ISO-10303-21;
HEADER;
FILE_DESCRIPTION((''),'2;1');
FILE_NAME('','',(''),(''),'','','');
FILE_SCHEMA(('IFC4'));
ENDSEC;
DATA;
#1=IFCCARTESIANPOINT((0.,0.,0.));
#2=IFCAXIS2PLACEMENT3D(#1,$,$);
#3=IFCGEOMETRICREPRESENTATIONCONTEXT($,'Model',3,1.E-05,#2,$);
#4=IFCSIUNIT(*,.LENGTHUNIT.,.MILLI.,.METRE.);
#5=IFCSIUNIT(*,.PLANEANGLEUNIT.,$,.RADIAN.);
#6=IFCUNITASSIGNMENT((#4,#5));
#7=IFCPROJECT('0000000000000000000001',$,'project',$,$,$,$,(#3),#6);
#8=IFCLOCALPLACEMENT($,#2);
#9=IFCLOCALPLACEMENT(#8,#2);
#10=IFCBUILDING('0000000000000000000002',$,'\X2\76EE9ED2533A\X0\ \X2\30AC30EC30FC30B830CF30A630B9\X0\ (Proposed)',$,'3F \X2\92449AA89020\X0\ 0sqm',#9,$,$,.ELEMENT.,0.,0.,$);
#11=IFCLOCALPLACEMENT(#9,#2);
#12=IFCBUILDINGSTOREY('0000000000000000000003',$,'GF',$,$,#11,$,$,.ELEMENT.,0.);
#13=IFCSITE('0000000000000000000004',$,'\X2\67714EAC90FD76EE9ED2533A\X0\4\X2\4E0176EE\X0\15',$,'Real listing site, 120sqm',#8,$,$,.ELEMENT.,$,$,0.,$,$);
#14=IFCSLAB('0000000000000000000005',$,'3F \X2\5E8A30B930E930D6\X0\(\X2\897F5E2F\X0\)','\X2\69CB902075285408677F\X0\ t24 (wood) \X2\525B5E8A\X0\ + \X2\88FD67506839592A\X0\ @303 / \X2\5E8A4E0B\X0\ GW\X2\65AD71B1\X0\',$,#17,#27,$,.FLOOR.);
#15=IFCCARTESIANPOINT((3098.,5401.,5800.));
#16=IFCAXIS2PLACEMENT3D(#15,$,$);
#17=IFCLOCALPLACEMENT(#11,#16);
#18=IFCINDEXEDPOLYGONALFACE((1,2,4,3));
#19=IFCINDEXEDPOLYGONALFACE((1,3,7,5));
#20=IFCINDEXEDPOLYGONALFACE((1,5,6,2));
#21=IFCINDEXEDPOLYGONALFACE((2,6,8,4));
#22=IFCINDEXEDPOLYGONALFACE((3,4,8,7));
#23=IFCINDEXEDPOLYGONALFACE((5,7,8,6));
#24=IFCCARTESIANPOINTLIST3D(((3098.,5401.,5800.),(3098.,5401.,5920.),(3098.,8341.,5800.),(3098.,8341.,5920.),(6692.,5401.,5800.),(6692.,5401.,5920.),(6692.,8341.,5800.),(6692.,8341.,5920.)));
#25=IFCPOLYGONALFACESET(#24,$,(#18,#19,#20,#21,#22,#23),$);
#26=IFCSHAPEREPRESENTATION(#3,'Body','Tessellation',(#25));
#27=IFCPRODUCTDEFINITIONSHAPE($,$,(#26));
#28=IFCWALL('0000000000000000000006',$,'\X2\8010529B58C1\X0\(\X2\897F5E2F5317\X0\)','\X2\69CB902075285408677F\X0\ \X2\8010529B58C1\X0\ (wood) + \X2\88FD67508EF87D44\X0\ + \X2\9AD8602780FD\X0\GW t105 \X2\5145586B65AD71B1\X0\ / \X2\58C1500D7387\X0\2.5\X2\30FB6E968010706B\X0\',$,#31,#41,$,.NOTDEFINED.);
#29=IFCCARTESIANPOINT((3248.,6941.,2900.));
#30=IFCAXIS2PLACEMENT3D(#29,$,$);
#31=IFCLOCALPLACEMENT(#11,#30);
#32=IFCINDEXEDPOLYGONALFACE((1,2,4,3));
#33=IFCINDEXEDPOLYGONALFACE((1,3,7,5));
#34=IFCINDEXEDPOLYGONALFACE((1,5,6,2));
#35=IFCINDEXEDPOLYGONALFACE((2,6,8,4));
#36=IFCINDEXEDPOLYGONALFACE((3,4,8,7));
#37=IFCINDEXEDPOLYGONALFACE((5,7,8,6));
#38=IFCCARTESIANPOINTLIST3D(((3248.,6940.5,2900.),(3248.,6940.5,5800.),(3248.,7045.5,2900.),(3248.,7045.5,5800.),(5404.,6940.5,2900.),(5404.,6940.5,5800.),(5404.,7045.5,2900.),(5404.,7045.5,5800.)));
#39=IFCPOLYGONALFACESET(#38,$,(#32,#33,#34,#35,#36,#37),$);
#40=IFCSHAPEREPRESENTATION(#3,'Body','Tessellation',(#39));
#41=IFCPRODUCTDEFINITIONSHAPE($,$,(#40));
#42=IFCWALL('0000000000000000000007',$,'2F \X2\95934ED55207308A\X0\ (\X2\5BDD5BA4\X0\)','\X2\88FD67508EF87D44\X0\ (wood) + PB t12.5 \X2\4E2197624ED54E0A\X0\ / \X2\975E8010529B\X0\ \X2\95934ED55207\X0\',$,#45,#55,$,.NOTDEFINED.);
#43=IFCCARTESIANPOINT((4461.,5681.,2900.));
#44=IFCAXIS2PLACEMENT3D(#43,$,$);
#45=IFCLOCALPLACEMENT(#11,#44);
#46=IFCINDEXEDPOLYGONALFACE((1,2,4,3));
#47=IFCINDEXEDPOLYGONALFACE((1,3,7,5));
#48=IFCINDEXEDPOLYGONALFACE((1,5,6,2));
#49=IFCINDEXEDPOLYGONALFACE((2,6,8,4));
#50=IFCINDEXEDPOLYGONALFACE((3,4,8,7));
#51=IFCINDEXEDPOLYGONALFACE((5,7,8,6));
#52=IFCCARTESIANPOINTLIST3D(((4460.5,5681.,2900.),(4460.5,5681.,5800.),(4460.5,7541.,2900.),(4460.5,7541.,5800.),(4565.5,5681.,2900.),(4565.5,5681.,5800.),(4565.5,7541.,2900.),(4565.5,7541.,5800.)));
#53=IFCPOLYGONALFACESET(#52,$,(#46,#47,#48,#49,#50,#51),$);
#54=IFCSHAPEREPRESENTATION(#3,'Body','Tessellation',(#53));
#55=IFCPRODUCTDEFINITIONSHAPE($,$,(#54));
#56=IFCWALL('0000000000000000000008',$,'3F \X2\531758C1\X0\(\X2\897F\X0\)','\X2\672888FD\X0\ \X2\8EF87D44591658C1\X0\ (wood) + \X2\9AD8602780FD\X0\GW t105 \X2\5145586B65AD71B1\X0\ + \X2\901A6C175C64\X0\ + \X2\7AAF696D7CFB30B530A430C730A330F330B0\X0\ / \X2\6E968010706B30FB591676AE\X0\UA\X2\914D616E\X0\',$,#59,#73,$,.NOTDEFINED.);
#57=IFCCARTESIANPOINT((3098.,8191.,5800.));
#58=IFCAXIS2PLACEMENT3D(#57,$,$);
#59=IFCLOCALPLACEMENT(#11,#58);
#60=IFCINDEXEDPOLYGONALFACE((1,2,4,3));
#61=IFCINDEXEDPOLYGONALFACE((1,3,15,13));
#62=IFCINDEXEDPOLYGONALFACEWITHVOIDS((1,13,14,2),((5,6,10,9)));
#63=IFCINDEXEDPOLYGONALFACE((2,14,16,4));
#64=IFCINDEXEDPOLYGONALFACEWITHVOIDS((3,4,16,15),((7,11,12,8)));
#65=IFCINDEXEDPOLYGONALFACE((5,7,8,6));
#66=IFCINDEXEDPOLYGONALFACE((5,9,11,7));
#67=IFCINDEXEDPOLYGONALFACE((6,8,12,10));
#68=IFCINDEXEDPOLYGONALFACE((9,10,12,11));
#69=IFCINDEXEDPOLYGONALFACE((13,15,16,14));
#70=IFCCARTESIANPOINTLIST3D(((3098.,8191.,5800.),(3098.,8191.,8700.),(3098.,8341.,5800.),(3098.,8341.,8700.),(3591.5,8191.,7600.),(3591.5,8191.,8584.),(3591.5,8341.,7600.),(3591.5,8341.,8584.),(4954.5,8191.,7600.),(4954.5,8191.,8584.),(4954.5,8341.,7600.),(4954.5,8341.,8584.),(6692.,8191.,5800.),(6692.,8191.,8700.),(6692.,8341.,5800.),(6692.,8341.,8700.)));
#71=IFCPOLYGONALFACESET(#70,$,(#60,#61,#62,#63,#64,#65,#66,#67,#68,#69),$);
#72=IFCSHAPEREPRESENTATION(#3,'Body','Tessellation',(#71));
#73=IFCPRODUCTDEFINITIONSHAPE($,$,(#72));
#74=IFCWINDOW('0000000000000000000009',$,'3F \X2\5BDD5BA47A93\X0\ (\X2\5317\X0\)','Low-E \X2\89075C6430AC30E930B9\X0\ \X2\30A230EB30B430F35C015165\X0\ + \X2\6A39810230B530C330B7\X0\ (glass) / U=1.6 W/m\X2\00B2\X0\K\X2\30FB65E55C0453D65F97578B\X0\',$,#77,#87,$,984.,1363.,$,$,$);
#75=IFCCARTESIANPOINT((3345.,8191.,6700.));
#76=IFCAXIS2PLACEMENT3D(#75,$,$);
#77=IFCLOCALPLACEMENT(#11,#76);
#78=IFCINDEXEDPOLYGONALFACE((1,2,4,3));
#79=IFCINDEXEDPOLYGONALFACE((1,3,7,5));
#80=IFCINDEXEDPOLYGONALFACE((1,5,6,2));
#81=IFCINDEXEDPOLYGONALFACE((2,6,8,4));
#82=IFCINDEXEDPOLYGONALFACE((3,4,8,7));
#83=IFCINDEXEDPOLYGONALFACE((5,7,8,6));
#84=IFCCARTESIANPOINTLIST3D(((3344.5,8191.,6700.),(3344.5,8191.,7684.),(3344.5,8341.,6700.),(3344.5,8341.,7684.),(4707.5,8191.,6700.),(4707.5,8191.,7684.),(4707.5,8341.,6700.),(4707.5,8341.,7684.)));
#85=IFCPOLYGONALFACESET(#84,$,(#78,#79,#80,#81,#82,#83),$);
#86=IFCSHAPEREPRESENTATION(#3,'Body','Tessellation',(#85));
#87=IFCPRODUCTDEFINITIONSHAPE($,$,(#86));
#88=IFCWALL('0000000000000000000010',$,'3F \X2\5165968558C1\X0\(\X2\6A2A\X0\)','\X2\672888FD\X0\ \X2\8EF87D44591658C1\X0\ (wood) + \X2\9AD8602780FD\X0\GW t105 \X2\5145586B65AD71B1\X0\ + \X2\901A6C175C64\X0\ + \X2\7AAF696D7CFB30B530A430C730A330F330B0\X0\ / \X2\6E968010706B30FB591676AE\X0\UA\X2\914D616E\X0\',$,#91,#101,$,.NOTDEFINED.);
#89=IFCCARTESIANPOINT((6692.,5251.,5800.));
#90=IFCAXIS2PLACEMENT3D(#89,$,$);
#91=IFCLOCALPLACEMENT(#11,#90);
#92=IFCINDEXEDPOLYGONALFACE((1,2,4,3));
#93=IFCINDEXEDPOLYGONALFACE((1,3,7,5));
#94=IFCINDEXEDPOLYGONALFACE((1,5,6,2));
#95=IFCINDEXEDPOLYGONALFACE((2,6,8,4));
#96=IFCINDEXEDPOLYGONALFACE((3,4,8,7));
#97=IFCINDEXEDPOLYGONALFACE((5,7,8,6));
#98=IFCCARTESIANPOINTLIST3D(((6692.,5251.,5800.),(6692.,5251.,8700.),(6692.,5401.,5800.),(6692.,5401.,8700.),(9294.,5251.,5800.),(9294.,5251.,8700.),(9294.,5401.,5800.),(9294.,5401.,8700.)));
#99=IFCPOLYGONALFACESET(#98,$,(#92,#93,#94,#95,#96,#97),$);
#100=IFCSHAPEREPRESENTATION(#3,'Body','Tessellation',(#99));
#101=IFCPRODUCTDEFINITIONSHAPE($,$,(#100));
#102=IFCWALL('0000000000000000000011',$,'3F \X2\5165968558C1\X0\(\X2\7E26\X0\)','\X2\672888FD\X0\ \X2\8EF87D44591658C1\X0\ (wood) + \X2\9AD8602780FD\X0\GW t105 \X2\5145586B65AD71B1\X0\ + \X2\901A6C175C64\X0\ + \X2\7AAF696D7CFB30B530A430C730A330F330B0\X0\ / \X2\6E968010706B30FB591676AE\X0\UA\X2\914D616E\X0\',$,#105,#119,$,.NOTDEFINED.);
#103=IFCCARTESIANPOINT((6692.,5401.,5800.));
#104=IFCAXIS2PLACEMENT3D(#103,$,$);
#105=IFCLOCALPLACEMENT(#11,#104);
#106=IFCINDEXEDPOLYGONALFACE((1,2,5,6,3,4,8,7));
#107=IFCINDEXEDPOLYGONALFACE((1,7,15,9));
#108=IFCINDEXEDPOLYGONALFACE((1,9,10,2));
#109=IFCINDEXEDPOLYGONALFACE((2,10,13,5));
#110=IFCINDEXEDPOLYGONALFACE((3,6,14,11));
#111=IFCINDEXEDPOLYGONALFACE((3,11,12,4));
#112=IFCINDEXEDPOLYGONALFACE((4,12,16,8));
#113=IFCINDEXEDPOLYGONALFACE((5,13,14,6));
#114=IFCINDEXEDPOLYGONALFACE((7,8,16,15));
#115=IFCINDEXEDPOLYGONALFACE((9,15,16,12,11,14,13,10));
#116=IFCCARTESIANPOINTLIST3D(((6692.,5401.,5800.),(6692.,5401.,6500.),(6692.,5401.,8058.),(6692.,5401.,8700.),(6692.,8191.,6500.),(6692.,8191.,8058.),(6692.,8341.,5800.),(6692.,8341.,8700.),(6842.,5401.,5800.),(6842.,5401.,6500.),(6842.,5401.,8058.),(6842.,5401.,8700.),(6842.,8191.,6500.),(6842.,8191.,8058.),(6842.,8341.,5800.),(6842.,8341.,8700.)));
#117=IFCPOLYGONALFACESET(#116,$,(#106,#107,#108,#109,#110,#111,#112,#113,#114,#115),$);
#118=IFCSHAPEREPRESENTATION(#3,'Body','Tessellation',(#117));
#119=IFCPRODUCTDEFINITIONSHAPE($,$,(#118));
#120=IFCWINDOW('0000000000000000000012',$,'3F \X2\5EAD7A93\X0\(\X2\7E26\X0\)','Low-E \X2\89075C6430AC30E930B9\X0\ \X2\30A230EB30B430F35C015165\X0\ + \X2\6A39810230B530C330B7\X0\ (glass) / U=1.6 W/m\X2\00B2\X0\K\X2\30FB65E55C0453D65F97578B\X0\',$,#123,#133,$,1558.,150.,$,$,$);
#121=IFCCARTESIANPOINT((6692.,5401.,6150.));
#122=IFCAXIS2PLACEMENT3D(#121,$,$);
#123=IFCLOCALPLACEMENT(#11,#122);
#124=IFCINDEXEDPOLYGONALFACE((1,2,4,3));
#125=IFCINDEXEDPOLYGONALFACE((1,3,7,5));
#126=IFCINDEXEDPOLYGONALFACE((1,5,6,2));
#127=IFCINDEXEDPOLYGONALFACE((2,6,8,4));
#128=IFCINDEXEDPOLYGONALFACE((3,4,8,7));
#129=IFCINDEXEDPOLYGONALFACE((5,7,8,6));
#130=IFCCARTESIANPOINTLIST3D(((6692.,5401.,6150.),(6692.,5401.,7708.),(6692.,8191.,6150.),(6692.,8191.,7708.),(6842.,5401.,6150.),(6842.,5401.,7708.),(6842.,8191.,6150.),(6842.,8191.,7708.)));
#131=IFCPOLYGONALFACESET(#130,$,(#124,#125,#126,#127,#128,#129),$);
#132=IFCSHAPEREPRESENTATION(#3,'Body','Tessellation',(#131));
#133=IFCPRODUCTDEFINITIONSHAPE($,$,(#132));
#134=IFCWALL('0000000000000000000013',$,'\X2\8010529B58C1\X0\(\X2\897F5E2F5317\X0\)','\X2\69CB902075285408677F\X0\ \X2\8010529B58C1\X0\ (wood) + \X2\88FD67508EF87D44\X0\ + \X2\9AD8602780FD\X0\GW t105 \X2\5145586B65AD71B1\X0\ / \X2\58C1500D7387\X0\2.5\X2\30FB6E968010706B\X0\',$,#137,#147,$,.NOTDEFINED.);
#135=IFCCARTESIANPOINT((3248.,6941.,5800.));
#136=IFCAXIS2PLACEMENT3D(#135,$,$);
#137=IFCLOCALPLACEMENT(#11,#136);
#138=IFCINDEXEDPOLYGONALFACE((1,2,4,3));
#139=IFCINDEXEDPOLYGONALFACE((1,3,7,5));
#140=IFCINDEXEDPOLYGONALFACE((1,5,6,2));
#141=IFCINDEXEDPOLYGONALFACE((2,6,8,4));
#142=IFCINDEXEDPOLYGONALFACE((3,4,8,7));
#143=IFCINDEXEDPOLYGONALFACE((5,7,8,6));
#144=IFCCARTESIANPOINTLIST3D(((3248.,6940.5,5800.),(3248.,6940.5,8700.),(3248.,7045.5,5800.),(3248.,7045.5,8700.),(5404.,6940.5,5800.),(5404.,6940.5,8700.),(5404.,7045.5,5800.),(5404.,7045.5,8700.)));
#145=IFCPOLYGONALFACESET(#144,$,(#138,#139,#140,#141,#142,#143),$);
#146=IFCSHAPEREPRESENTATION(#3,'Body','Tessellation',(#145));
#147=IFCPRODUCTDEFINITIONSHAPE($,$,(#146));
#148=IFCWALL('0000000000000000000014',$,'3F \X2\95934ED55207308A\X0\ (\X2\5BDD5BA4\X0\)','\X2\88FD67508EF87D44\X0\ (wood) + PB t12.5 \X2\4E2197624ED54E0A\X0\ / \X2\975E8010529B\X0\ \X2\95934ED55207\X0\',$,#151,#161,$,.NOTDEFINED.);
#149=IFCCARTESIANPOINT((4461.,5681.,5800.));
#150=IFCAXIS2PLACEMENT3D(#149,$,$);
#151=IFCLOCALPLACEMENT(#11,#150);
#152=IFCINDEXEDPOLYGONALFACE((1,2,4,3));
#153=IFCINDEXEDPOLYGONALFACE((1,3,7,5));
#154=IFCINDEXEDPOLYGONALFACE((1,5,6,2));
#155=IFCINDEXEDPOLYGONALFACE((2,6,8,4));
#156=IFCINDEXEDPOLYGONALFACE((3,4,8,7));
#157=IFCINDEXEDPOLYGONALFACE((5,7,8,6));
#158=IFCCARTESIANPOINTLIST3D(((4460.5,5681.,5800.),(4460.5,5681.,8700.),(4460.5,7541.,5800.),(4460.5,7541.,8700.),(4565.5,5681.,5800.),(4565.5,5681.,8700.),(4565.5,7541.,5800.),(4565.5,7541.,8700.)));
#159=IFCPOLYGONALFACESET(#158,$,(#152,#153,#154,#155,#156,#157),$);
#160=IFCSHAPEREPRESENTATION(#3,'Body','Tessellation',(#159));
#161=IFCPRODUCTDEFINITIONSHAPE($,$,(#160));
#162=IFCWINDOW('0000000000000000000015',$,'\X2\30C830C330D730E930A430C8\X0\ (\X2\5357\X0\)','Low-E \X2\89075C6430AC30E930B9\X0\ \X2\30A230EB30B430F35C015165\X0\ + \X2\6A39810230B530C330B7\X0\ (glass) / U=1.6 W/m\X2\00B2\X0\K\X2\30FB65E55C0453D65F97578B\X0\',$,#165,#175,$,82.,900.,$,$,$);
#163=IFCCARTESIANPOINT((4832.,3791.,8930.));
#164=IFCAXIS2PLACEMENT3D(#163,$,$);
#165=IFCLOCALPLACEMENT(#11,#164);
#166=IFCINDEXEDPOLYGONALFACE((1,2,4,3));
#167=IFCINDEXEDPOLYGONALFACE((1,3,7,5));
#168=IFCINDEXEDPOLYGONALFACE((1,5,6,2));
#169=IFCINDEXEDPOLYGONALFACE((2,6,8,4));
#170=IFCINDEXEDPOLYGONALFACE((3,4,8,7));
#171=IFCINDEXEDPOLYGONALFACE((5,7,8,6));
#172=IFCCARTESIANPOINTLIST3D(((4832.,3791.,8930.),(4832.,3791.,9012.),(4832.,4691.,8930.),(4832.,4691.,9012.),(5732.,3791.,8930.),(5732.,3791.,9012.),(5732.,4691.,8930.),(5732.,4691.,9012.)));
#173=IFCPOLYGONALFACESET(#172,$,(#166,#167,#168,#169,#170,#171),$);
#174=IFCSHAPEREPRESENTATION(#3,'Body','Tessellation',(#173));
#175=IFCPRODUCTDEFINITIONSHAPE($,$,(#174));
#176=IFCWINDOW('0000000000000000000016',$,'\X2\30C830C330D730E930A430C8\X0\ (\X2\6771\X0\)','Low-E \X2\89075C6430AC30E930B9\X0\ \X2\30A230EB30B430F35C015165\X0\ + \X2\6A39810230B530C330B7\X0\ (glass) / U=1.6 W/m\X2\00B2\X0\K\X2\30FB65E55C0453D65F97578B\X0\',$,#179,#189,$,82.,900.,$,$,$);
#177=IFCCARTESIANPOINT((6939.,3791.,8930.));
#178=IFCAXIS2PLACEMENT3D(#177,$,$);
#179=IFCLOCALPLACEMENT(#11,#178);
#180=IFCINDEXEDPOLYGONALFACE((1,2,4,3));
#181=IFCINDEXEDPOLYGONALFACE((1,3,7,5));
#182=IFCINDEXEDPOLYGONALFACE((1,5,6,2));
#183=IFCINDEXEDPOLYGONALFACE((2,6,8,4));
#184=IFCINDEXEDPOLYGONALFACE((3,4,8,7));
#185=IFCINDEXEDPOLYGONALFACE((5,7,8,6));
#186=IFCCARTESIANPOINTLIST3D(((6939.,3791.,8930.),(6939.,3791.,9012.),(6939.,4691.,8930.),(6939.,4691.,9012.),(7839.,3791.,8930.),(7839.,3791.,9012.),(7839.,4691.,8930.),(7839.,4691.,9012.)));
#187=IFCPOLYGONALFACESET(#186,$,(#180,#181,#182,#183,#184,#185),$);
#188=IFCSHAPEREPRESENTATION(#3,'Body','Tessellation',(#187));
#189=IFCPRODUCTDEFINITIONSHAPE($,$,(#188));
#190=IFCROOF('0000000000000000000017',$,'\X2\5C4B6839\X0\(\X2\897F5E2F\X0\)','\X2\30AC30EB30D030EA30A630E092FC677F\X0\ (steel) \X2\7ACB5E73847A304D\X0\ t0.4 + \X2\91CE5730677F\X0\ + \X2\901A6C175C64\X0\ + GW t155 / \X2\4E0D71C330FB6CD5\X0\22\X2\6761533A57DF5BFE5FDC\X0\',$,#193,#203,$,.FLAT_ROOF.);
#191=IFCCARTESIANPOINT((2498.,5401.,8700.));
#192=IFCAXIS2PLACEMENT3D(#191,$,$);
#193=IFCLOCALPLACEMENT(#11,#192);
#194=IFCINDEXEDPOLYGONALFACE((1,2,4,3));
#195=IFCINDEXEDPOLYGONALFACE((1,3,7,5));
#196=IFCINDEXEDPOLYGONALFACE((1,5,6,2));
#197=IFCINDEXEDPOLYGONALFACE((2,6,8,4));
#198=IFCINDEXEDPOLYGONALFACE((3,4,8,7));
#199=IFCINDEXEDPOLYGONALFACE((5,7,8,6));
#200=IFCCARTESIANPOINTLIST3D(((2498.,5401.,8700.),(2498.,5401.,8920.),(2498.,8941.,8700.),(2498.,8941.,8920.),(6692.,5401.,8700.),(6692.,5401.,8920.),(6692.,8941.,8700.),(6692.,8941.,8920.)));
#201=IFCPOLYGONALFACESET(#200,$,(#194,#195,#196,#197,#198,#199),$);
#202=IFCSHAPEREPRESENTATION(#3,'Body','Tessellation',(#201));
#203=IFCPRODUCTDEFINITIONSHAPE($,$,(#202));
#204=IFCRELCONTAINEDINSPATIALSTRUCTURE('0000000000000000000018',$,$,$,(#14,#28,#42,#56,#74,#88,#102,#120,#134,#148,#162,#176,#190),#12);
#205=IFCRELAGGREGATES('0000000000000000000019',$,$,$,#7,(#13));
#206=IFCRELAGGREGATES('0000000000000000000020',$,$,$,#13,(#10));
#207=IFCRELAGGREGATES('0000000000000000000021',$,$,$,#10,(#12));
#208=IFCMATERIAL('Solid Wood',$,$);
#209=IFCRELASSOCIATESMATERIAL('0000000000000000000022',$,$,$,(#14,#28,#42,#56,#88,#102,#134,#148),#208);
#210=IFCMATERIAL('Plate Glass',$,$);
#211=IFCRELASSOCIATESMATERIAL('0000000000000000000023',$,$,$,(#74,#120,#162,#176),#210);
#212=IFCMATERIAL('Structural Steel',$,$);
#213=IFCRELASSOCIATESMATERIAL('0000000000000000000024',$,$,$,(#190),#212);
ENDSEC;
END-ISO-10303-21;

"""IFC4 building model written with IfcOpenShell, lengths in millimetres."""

from ifc_helpers import new_model, si_unit, frame, frame_2d, origin, place, context, project, spatial, rectangle, extrude, material, element, fill, save


model = new_model("IFC4")

# Units and contexts
model_context = context("Model", 3, precision=1e-05, world=origin())
ifc_project = project(units=[si_unit("LENGTHUNIT", "METRE", prefix="MILLI"), si_unit("PLANEANGLEUNIT", "RADIAN")], contexts=[model_context])

# Site, building, storey
site_placement = place(None, origin())
site = spatial("IfcSite", under=ifc_project, at=site_placement, Name="東京都目黒区4丁目15", ObjectType="Real listing site, 120sqm", CompositionType="ELEMENT", RefElevation=0.0)
building_placement = place(site_placement, origin())
building = spatial("IfcBuilding", under=site, at=building_placement, Name="目黒区 ガレージハウス (Proposed)", ObjectType="3F 鉄骨造 0sqm", CompositionType="ELEMENT", ElevationOfRefHeight=0.0, ElevationOfTerrain=0.0)
storey_placement = place(building_placement, origin())
storey = spatial("IfcBuildingStorey", under=building, at=storey_placement, Name="GF", CompositionType="ELEMENT", Elevation=0.0)

# Slab
ifc_material_1 = material(Name="Solid Wood")
slab_placement = place(storey_placement, frame((3098.0, 5401.0, 5800.0)))
element("IfcSlab", 1, at=slab_placement, inside=storey, material=ifc_material_1, Name="3F 床スラブ(西帯)", Description="構造用合板 t24 (wood) 剛床 + 製材根太 @303 / 床下 GW断熱", PredefinedType="FLOOR", context=model_context, shape_type="SweptSolid", body=[
    extrude(rectangle(XDim=3594.0, YDim=2940.0, at=frame_2d((1797.0, 1470.0))), frame((3098.0, 5401.0, 5800.0)), (0.0, 0.0, 1.0), 120.0),
])

# Walls
wall_1_placement = place(storey_placement, frame((3248.0, 6941.0, 2900.0)))
element("IfcWall", 2, at=wall_1_placement, inside=storey, material=ifc_material_1, Name="耐力壁(西帯北)", Description="構造用合板 耐力壁 (wood) + 製材軸組 + 高性能GW t105 充填断熱 / 壁倍率2.5・準耐火", PredefinedType="NOTDEFINED", context=model_context, shape_type="SweptSolid", body=[
    extrude(rectangle(XDim=2156.0, YDim=105.0, at=frame_2d((1078.0, 52.0))), frame((3248.0, 6941.0, 2900.0)), (0.0, 0.0, 1.0), 2900.0),
])
wall_2_placement = place(storey_placement, frame((4461.0, 5681.0, 2900.0)))
element("IfcWall", 3, at=wall_2_placement, inside=storey, material=ifc_material_1, Name="2F 間仕切り (寝室)", Description="製材軸組 (wood) + PB t12.5 両面仕上 / 非耐力 間仕切", PredefinedType="NOTDEFINED", context=model_context, shape_type="SweptSolid", body=[
    extrude(rectangle(XDim=105.0, YDim=1860.0, at=frame_2d((52.0, 930.0))), frame((4461.0, 5681.0, 2900.0)), (0.0, 0.0, 1.0), 2900.0),
])

# Wall, opening, window
wall_3_placement = place(storey_placement, frame((3098.0, 8191.0, 5800.0)))
wall_3 = element("IfcWall", 4, at=wall_3_placement, inside=storey, material=ifc_material_1, Name="3F 北壁(西)", Description="木製 軸組外壁 (wood) + 高性能GW t105 充填断熱 + 通気層 + 窯業系サイディング / 準耐火・外皮UA配慮", PredefinedType="NOTDEFINED", context=model_context, shape_type="SweptSolid", body=[
    extrude(rectangle(XDim=3594.0, YDim=150.0, at=frame_2d((1797.0, 75.0))), frame((3098.0, 8191.0, 5800.0)), (0.0, 0.0, 1.0), 2900.0),
])
opening_1_placement = place(storey_placement, frame((3345.0, 8191.0, 6700.0)))
opening_1 = element("IfcOpeningElement", 5, at=opening_1_placement, cuts=wall_3, PredefinedType="NOTDEFINED", context=model_context, shape_type="SweptSolid", body=[
    extrude(rectangle(XDim=1363.0, YDim=150.0, at=frame_2d((681.0, 75.0))), frame((3345.0, 8191.0, 6700.0)), (0.0, 0.0, 1.0), 984.0),
])
ifc_material_2 = material(Name="Plate Glass")
window_1_placement = place(storey_placement, frame((3345.0, 8191.0, 6700.0)))
window_1 = element("IfcWindow", 6, at=window_1_placement, inside=storey, material=ifc_material_2, Name="3F 寝室窓 (北)", Description="Low-E 複層ガラス アルゴン封入 + 樹脂サッシ (glass) / U=1.6 W/m²K・日射取得型", OverallHeight=984.0, OverallWidth=1363.0, context=model_context, shape_type="SweptSolid", body=[
    extrude(rectangle(XDim=1363.0, YDim=150.0, at=frame_2d((681.0, 75.0))), frame((3345.0, 8191.0, 6700.0)), (0.0, 0.0, 1.0), 984.0),
])
fill(opening_1, window_1)

# Wall
wall_4_placement = place(storey_placement, frame((6692.0, 5251.0, 5800.0)))
element("IfcWall", 7, at=wall_4_placement, inside=storey, material=ifc_material_1, Name="3F 入隅壁(横)", Description="木製 軸組外壁 (wood) + 高性能GW t105 充填断熱 + 通気層 + 窯業系サイディング / 準耐火・外皮UA配慮", PredefinedType="NOTDEFINED", context=model_context, shape_type="SweptSolid", body=[
    extrude(rectangle(XDim=2602.0, YDim=150.0, at=frame_2d((1301.0, 75.0))), frame((6692.0, 5251.0, 5800.0)), (0.0, 0.0, 1.0), 2900.0),
])

# Wall, opening, window
wall_5_placement = place(storey_placement, frame((6692.0, 5401.0, 5800.0)))
wall_5 = element("IfcWall", 8, at=wall_5_placement, inside=storey, material=ifc_material_1, Name="3F 入隅壁(縦)", Description="木製 軸組外壁 (wood) + 高性能GW t105 充填断熱 + 通気層 + 窯業系サイディング / 準耐火・外皮UA配慮", PredefinedType="NOTDEFINED", context=model_context, shape_type="SweptSolid", body=[
    extrude(rectangle(XDim=150.0, YDim=2940.0, at=frame_2d((75.0, 1470.0))), frame((6692.0, 5401.0, 5800.0)), (0.0, 0.0, 1.0), 2900.0),
])
opening_2_placement = place(storey_placement, frame((6692.0, 5401.0, 6150.0)))
opening_2 = element("IfcOpeningElement", 9, at=opening_2_placement, cuts=wall_5, PredefinedType="NOTDEFINED", context=model_context, shape_type="SweptSolid", body=[
    extrude(rectangle(XDim=150.0, YDim=2790.0, at=frame_2d((75.0, 1395.0))), frame((6692.0, 5401.0, 6150.0)), (0.0, 0.0, 1.0), 1558.0),
])
window_2_placement = place(storey_placement, frame((6692.0, 5401.0, 6150.0)))
window_2 = element("IfcWindow", 10, at=window_2_placement, inside=storey, material=ifc_material_2, Name="3F 庭窓(縦)", Description="Low-E 複層ガラス アルゴン封入 + 樹脂サッシ (glass) / U=1.6 W/m²K・日射取得型", OverallHeight=1558.0, OverallWidth=150.0, context=model_context, shape_type="SweptSolid", body=[
    extrude(rectangle(XDim=150.0, YDim=2790.0, at=frame_2d((75.0, 1395.0))), frame((6692.0, 5401.0, 6150.0)), (0.0, 0.0, 1.0), 1558.0),
])
fill(opening_2, window_2)

# Walls
wall_6_placement = place(storey_placement, frame((3248.0, 6941.0, 5800.0)))
element("IfcWall", 11, at=wall_6_placement, inside=storey, material=ifc_material_1, Name="耐力壁(西帯北)", Description="構造用合板 耐力壁 (wood) + 製材軸組 + 高性能GW t105 充填断熱 / 壁倍率2.5・準耐火", PredefinedType="NOTDEFINED", context=model_context, shape_type="SweptSolid", body=[
    extrude(rectangle(XDim=2156.0, YDim=105.0, at=frame_2d((1078.0, 52.0))), frame((3248.0, 6941.0, 5800.0)), (0.0, 0.0, 1.0), 2900.0),
])
wall_7_placement = place(storey_placement, frame((4461.0, 5681.0, 5800.0)))
element("IfcWall", 12, at=wall_7_placement, inside=storey, material=ifc_material_1, Name="3F 間仕切り (寝室)", Description="製材軸組 (wood) + PB t12.5 両面仕上 / 非耐力 間仕切", PredefinedType="NOTDEFINED", context=model_context, shape_type="SweptSolid", body=[
    extrude(rectangle(XDim=105.0, YDim=1860.0, at=frame_2d((52.0, 930.0))), frame((4461.0, 5681.0, 5800.0)), (0.0, 0.0, 1.0), 2900.0),
])

# Windows
window_3_placement = place(storey_placement, frame((4832.0, 3791.0, 8930.0)))
element("IfcWindow", 13, at=window_3_placement, inside=storey, material=ifc_material_2, Name="トップライト (南)", Description="Low-E 複層ガラス アルゴン封入 + 樹脂サッシ (glass) / U=1.6 W/m²K・日射取得型", OverallHeight=82.0, OverallWidth=900.0, context=model_context, shape_type="SweptSolid", body=[
    extrude(rectangle(XDim=900.0, YDim=900.0, at=frame_2d((450.0, 450.0))), frame((4832.0, 3791.0, 8930.0)), (0.0, 0.0, 1.0), 82.0),
])
window_4_placement = place(storey_placement, frame((6939.0, 3791.0, 8930.0)))
element("IfcWindow", 14, at=window_4_placement, inside=storey, material=ifc_material_2, Name="トップライト (東)", Description="Low-E 複層ガラス アルゴン封入 + 樹脂サッシ (glass) / U=1.6 W/m²K・日射取得型", OverallHeight=82.0, OverallWidth=900.0, context=model_context, shape_type="SweptSolid", body=[
    extrude(rectangle(XDim=900.0, YDim=900.0, at=frame_2d((450.0, 450.0))), frame((6939.0, 3791.0, 8930.0)), (0.0, 0.0, 1.0), 82.0),
])

# Roof
ifc_material_3 = material(Name="Structural Steel")
for number, where, name in (
    (15, (2498.0, 5401.0, 8700.0), "屋根(西帯)"),
):
    element("IfcRoof", number, at=place(storey_placement, frame(where)), inside=storey, material=ifc_material_3, Name=name, Description="ガルバリウム鋼板 (steel) 立平葺き t0.4 + 野地板 + 通気層 + GW t155 / 不燃・法22条区域対応", PredefinedType="FLAT_ROOF", context=model_context, shape_type="SweptSolid", body=[
        extrude(rectangle(XDim=4194.0, YDim=3540.0, at=frame_2d((2097.0, 1770.0))), frame((2498.0, 5401.0, 8700.0)), (0.0, 0.0, 1.0), 220.0),
    ])

save(model, "model.ifc")
